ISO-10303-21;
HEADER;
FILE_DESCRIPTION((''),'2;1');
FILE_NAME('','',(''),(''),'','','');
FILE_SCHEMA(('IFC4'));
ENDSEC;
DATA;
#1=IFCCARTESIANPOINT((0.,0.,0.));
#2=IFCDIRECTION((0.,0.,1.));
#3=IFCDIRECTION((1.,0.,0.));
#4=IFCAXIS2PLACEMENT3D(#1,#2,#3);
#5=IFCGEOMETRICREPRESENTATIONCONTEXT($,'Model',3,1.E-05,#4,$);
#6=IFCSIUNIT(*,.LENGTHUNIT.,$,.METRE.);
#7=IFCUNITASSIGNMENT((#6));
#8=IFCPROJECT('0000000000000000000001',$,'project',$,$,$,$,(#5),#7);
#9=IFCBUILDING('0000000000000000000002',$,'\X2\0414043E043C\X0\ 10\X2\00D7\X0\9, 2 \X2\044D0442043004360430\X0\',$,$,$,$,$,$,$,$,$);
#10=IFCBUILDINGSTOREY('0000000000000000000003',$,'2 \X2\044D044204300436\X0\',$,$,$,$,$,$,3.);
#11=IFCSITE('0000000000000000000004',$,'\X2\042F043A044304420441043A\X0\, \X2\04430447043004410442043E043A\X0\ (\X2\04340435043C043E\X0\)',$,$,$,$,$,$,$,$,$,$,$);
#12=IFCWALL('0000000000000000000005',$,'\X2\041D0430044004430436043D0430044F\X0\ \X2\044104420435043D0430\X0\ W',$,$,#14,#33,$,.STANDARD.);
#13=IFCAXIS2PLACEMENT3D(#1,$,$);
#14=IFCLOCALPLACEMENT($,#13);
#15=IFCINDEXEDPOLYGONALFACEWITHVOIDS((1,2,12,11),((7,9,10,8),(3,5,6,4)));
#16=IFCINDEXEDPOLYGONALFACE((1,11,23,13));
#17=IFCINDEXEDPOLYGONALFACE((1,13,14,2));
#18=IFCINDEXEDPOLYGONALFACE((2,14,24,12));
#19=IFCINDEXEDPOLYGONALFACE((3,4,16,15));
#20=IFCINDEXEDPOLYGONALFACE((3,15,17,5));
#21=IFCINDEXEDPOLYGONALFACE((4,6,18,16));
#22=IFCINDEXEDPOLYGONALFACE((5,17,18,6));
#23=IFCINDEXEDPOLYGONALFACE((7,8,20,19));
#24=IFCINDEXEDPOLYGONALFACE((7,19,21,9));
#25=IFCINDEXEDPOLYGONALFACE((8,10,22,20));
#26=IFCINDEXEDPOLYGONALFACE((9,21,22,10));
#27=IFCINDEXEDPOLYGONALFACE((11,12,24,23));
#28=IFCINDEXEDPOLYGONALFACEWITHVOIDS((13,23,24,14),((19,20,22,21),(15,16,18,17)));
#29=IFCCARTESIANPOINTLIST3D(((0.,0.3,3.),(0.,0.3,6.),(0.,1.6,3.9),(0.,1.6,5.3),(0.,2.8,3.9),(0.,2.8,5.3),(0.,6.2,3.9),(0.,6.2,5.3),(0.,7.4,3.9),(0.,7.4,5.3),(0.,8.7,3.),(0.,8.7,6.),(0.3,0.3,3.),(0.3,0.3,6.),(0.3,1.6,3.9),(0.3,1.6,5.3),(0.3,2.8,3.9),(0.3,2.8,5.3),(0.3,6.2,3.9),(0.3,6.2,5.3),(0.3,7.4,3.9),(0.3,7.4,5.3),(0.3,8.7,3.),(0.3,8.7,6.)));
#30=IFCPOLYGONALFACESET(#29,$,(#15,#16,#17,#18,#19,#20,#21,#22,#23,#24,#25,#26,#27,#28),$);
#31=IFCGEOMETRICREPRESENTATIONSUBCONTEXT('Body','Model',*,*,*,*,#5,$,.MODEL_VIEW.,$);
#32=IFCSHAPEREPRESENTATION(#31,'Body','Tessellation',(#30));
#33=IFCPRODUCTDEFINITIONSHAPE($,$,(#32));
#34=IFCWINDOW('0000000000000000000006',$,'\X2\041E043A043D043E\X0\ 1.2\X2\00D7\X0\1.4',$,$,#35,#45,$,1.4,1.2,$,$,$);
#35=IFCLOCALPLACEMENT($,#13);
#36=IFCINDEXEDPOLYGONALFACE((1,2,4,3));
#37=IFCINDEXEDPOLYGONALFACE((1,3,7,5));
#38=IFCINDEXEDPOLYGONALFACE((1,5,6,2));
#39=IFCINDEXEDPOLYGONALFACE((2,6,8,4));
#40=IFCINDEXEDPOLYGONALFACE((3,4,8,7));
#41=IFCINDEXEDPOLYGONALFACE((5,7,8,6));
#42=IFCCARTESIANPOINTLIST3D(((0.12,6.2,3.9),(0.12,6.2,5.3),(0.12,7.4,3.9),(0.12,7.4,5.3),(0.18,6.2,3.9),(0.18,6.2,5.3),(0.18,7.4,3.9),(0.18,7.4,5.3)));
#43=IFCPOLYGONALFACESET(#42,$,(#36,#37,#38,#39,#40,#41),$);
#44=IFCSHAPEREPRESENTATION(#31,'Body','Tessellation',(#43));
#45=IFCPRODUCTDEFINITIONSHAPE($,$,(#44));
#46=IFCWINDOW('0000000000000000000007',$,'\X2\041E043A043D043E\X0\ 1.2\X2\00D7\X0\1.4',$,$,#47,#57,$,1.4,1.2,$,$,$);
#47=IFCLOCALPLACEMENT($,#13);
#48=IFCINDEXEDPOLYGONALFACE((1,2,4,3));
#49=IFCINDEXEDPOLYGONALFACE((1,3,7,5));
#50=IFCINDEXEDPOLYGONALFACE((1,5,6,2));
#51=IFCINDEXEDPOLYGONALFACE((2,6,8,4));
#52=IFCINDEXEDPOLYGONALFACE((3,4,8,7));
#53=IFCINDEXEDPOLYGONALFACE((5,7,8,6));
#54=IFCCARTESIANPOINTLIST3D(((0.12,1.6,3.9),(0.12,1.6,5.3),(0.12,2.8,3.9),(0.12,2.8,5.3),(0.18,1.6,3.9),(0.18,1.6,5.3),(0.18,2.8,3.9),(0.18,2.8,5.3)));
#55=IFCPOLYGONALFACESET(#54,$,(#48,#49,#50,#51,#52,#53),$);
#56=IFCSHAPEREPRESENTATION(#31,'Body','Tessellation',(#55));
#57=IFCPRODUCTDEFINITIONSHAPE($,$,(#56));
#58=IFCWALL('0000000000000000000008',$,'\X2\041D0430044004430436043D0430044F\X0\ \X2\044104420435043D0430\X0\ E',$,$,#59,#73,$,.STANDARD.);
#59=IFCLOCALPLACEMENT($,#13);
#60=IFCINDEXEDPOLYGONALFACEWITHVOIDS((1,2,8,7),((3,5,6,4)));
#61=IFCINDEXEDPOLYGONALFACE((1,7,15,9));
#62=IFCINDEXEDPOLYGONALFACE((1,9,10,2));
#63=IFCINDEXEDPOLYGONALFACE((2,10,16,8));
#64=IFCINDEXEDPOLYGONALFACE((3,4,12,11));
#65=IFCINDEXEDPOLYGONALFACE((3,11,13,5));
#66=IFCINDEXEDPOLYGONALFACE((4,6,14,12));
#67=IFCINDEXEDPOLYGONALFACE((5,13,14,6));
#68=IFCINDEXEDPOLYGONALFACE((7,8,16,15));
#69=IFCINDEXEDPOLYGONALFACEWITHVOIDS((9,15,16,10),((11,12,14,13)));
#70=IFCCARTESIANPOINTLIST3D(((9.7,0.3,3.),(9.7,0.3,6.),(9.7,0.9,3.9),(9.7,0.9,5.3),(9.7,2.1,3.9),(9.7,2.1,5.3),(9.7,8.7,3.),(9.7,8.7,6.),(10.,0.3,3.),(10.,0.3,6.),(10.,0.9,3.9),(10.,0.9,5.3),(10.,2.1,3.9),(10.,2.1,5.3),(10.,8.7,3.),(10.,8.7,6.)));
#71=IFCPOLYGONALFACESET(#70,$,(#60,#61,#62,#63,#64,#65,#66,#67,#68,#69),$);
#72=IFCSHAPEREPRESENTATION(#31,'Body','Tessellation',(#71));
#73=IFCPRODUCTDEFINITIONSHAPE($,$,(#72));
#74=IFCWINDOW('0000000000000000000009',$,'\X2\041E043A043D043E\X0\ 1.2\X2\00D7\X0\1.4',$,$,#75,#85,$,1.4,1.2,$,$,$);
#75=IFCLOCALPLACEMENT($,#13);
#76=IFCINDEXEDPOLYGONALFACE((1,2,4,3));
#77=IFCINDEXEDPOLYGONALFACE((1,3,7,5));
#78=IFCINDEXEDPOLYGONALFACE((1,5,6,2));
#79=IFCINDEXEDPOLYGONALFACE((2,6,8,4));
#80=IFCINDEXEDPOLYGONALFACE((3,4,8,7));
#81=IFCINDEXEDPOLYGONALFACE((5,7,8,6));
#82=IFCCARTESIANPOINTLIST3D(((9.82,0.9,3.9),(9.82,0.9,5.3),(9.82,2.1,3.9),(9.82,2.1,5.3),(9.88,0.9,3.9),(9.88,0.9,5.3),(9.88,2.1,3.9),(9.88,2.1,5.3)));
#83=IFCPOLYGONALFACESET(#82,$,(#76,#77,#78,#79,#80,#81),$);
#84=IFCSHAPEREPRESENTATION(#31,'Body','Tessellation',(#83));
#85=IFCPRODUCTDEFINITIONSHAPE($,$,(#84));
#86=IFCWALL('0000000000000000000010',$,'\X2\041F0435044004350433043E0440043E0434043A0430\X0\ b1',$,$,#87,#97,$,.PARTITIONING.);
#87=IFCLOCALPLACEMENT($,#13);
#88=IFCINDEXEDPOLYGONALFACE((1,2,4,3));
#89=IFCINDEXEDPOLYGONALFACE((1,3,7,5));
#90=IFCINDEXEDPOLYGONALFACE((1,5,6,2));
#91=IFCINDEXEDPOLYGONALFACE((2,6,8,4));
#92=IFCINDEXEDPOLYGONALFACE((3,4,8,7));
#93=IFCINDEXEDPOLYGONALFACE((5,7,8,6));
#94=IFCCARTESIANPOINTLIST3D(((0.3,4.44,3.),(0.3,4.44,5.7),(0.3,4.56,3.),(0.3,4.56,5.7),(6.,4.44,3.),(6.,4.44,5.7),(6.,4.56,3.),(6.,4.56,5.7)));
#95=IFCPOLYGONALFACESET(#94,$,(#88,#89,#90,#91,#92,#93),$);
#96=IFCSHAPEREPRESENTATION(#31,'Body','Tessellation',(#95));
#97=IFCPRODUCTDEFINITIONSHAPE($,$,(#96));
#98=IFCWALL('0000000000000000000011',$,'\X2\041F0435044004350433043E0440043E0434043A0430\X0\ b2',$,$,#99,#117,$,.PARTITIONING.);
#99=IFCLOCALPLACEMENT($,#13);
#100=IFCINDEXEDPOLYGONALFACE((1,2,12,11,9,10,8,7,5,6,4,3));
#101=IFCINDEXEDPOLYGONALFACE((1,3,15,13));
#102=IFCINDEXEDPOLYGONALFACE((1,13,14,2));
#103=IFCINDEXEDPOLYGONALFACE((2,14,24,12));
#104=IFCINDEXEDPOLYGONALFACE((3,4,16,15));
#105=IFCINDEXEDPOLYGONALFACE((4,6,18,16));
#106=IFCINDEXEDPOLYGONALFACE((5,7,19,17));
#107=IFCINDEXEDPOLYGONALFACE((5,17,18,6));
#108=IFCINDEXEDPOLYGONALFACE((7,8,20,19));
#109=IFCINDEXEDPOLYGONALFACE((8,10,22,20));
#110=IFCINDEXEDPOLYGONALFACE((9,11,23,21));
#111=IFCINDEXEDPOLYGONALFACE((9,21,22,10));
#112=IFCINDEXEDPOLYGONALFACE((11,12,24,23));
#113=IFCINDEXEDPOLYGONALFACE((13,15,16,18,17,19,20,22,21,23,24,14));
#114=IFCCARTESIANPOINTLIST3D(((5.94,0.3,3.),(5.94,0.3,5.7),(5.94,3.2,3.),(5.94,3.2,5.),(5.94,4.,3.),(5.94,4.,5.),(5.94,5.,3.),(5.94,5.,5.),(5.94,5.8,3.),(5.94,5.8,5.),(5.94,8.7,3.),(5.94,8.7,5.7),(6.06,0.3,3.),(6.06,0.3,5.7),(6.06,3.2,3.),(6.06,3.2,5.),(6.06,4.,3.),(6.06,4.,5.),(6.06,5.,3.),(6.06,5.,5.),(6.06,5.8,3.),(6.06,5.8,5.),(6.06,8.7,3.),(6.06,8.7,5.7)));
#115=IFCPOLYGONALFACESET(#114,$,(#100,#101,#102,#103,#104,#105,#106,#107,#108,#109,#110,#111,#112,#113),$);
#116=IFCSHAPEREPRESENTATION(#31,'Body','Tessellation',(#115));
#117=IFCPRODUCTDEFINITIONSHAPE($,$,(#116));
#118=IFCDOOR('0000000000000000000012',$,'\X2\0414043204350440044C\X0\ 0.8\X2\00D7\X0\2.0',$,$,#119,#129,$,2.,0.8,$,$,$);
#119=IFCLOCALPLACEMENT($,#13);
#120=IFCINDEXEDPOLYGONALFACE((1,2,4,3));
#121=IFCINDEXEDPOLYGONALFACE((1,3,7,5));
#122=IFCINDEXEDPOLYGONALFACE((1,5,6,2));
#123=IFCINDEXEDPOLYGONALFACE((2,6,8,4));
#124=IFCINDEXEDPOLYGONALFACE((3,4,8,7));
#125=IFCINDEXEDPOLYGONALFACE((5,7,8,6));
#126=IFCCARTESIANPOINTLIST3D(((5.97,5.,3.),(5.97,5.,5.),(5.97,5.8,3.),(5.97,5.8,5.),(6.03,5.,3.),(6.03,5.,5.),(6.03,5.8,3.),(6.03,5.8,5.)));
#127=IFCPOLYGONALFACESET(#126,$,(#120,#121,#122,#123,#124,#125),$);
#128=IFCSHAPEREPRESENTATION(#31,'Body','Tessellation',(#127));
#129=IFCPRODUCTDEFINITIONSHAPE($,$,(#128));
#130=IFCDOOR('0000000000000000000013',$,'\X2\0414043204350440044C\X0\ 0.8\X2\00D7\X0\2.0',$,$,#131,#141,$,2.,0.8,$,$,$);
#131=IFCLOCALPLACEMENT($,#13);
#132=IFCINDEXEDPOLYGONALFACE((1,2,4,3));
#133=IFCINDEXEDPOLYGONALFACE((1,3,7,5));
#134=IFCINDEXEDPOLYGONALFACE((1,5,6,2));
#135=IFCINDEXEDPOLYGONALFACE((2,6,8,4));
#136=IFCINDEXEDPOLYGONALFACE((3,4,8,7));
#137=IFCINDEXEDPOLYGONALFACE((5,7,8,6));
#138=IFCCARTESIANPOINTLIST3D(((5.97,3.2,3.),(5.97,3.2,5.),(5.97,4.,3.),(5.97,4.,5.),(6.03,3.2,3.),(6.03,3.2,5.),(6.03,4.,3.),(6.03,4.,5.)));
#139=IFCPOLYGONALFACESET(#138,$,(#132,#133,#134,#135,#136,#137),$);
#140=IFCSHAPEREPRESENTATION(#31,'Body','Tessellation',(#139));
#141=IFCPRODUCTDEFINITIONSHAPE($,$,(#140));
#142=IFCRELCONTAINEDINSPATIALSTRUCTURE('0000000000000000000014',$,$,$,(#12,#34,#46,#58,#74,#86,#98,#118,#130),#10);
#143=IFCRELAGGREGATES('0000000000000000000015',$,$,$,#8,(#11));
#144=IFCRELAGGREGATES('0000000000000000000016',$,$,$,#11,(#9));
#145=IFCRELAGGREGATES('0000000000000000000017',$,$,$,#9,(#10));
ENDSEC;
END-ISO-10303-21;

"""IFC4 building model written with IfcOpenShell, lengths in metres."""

from ifc_helpers import new_model, si_unit, frame, origin_with_axes, place, context, subcontext, project, spatial, indexed_curve, outline, extrude, element, fill, save


model = new_model("IFC4")

# Units and contexts
model_context = context("Model", 3, precision=1e-05, world=origin_with_axes())
body_context = subcontext(model_context, "Body", "Model", "MODEL_VIEW")
ifc_project = project(units=[si_unit("LENGTHUNIT", "METRE")], contexts=[model_context])

# Site, building, storey
site = spatial("IfcSite", under=ifc_project, Name="Якутск, участок (демо)")
building = spatial("IfcBuilding", under=site, Name="Дом 10×9, 2 этажа")
storey = spatial("IfcBuildingStorey", under=building, Name="2 этаж", Elevation=3.0)

# Wall, openings, windows
wall_1_placement = place(None, frame((0.3, 0.3, 3.0), z_axis=(0.0, 0.0, 1.0), x_axis=(0.0, 1.0, 0.0)))
wall_1 = element("IfcWall", 1, at=wall_1_placement, inside=storey, Name="Наружная стена W", PredefinedType="STANDARD", context=body_context, shape_type="SweptSolid", body=[
    extrude(outline(indexed_curve([(0.0, 0.0), (0.0, 0.3), (8.4, 0.3), (8.4, 0.0), (0.0, 0.0)], self_intersect=False)), origin_with_axes(), (0.0, 0.0, 1.0), 3.0),
])
opening_1_placement = place(wall_1_placement, frame((5.9, -0.05, 0.9), z_axis=(0.0, 0.0, 1.0), x_axis=(1.0, 0.0, 0.0)))
opening_1 = element("IfcOpeningElement", 2, at=opening_1_placement, cuts=wall_1, context=body_context, shape_type="SweptSolid", body=[
    extrude(outline(indexed_curve([(0.0, 0.0), (0.0, 0.4), (1.2, 0.4), (1.2, 0.0), (0.0, 0.0)], self_intersect=False)), origin_with_axes(), (0.0, 0.0, 1.0), 1.4),
])
opening_2_placement = place(wall_1_placement, frame((1.3, -0.05, 0.9), z_axis=(0.0, 0.0, 1.0), x_axis=(1.0, 0.0, 0.0)))
opening_2 = element("IfcOpeningElement", 3, at=opening_2_placement, cuts=wall_1, context=body_context, shape_type="SweptSolid", body=[
    extrude(outline(indexed_curve([(0.0, 0.0), (0.0, 0.4), (1.2, 0.4), (1.2, 0.0), (0.0, 0.0)], self_intersect=False)), origin_with_axes(), (0.0, 0.0, 1.0), 1.4),
])
window_1_placement = place(opening_1_placement, frame((0.0, 0.17, 0.0), z_axis=(0.0, 0.0, 1.0), x_axis=(1.0, 0.0, 0.0)))
window_1 = element("IfcWindow", 4, at=window_1_placement, inside=storey, Name="Окно 1.2×1.4", OverallHeight=1.4, OverallWidth=1.2, context=body_context, shape_type="SweptSolid", body=[
    extrude(outline(indexed_curve([(0.0, 0.0), (0.0, 0.06), (1.2, 0.06), (1.2, 0.0), (0.0, 0.0)], self_intersect=False)), origin_with_axes(), (0.0, 0.0, 1.0), 1.4),
])
fill(opening_1, window_1)
window_2_placement = place(opening_2_placement, frame((0.0, 0.17, 0.0), z_axis=(0.0, 0.0, 1.0), x_axis=(1.0, 0.0, 0.0)))
window_2 = element("IfcWindow", 5, at=window_2_placement, inside=storey, Name="Окно 1.2×1.4", OverallHeight=1.4, OverallWidth=1.2, context=body_context, shape_type="SweptSolid", body=[
    extrude(outline(indexed_curve([(0.0, 0.0), (0.0, 0.06), (1.2, 0.06), (1.2, 0.0), (0.0, 0.0)], self_intersect=False)), origin_with_axes(), (0.0, 0.0, 1.0), 1.4),
])
fill(opening_2, window_2)

# Wall, opening, window
wall_2_placement = place(None, frame((10.0, 0.3, 3.0), z_axis=(0.0, 0.0, 1.0), x_axis=(0.0, 1.0, 0.0)))
wall_2 = element("IfcWall", 6, at=wall_2_placement, inside=storey, Name="Наружная стена E", PredefinedType="STANDARD", context=body_context, shape_type="SweptSolid", body=[
    extrude(outline(indexed_curve([(0.0, 0.0), (0.0, 0.3), (8.4, 0.3), (8.4, 0.0), (0.0, 0.0)], self_intersect=False)), origin_with_axes(), (0.0, 0.0, 1.0), 3.0),
])
opening_3_placement = place(wall_2_placement, frame((0.6, -0.05, 0.9), z_axis=(0.0, 0.0, 1.0), x_axis=(1.0, 0.0, 0.0)))
opening_3 = element("IfcOpeningElement", 7, at=opening_3_placement, cuts=wall_2, context=body_context, shape_type="SweptSolid", body=[
    extrude(outline(indexed_curve([(0.0, 0.0), (0.0, 0.4), (1.2, 0.4), (1.2, 0.0), (0.0, 0.0)], self_intersect=False)), origin_with_axes(), (0.0, 0.0, 1.0), 1.4),
])
window_3_placement = place(opening_3_placement, frame((0.0, 0.17, 0.0), z_axis=(0.0, 0.0, 1.0), x_axis=(1.0, 0.0, 0.0)))
window_3 = element("IfcWindow", 8, at=window_3_placement, inside=storey, Name="Окно 1.2×1.4", OverallHeight=1.4, OverallWidth=1.2, context=body_context, shape_type="SweptSolid", body=[
    extrude(outline(indexed_curve([(0.0, 0.0), (0.0, 0.06), (1.2, 0.06), (1.2, 0.0), (0.0, 0.0)], self_intersect=False)), origin_with_axes(), (0.0, 0.0, 1.0), 1.4),
])
fill(opening_3, window_3)

# Wall
wall_3_placement = place(None, frame((0.3, 4.44, 3.0), z_axis=(0.0, 0.0, 1.0), x_axis=(1.0, 0.0, 0.0)))
element("IfcWall", 9, at=wall_3_placement, inside=storey, Name="Перегородка b1", PredefinedType="PARTITIONING", context=body_context, shape_type="SweptSolid", body=[
    extrude(outline(indexed_curve([(0.0, 0.0), (0.0, 0.12), (5.7, 0.12), (5.7, 0.0), (0.0, 0.0)], self_intersect=False)), origin_with_axes(), (0.0, 0.0, 1.0), 2.7),
])

# Wall, openings, doors
wall_4_placement = place(None, frame((6.06, 0.3, 3.0), z_axis=(0.0, 0.0, 1.0), x_axis=(0.0, 1.0, 0.0)))
wall_4 = element("IfcWall", 10, at=wall_4_placement, inside=storey, Name="Перегородка b2", PredefinedType="PARTITIONING", context=body_context, shape_type="SweptSolid", body=[
    extrude(outline(indexed_curve([(0.0, 0.0), (0.0, 0.12), (8.4, 0.12), (8.4, 0.0), (0.0, 0.0)], self_intersect=False)), origin_with_axes(), (0.0, 0.0, 1.0), 2.7),
])
opening_4_placement = place(wall_4_placement, frame((4.7, -0.05, 0.0), z_axis=(0.0, 0.0, 1.0), x_axis=(1.0, 0.0, 0.0)))
opening_4 = element("IfcOpeningElement", 11, at=opening_4_placement, cuts=wall_4, context=body_context, shape_type="SweptSolid", body=[
    extrude(outline(indexed_curve([(0.0, 0.0), (0.0, 0.22), (0.8, 0.22), (0.8, 0.0), (0.0, 0.0)], self_intersect=False)), origin_with_axes(), (0.0, 0.0, 1.0), 2.0),
])
opening_5_placement = place(wall_4_placement, frame((2.9, -0.05, 0.0), z_axis=(0.0, 0.0, 1.0), x_axis=(1.0, 0.0, 0.0)))
opening_5 = element("IfcOpeningElement", 12, at=opening_5_placement, cuts=wall_4, context=body_context, shape_type="SweptSolid", body=[
    extrude(outline(indexed_curve([(0.0, 0.0), (0.0, 0.22), (0.8, 0.22), (0.8, 0.0), (0.0, 0.0)], self_intersect=False)), origin_with_axes(), (0.0, 0.0, 1.0), 2.0),
])
door_1_placement = place(opening_4_placement, frame((0.0, 0.08, 0.0), z_axis=(0.0, 0.0, 1.0), x_axis=(1.0, 0.0, 0.0)))
door_1 = element("IfcDoor", 13, at=door_1_placement, inside=storey, Name="Дверь 0.8×2.0", OverallHeight=2.0, OverallWidth=0.8, context=body_context, shape_type="SweptSolid", body=[
    extrude(outline(indexed_curve([(0.0, 0.0), (0.0, 0.06), (0.8, 0.06), (0.8, 0.0), (0.0, 0.0)], self_intersect=False)), origin_with_axes(), (0.0, 0.0, 1.0), 2.0),
])
fill(opening_4, door_1)
door_2_placement = place(opening_5_placement, frame((0.0, 0.08, 0.0), z_axis=(0.0, 0.0, 1.0), x_axis=(1.0, 0.0, 0.0)))
door_2 = element("IfcDoor", 14, at=door_2_placement, inside=storey, Name="Дверь 0.8×2.0", OverallHeight=2.0, OverallWidth=0.8, context=body_context, shape_type="SweptSolid", body=[
    extrude(outline(indexed_curve([(0.0, 0.0), (0.0, 0.06), (0.8, 0.06), (0.8, 0.0), (0.0, 0.0)], self_intersect=False)), origin_with_axes(), (0.0, 0.0, 1.0), 2.0),
])
fill(opening_5, door_2)

save(model, "model.ifc")
